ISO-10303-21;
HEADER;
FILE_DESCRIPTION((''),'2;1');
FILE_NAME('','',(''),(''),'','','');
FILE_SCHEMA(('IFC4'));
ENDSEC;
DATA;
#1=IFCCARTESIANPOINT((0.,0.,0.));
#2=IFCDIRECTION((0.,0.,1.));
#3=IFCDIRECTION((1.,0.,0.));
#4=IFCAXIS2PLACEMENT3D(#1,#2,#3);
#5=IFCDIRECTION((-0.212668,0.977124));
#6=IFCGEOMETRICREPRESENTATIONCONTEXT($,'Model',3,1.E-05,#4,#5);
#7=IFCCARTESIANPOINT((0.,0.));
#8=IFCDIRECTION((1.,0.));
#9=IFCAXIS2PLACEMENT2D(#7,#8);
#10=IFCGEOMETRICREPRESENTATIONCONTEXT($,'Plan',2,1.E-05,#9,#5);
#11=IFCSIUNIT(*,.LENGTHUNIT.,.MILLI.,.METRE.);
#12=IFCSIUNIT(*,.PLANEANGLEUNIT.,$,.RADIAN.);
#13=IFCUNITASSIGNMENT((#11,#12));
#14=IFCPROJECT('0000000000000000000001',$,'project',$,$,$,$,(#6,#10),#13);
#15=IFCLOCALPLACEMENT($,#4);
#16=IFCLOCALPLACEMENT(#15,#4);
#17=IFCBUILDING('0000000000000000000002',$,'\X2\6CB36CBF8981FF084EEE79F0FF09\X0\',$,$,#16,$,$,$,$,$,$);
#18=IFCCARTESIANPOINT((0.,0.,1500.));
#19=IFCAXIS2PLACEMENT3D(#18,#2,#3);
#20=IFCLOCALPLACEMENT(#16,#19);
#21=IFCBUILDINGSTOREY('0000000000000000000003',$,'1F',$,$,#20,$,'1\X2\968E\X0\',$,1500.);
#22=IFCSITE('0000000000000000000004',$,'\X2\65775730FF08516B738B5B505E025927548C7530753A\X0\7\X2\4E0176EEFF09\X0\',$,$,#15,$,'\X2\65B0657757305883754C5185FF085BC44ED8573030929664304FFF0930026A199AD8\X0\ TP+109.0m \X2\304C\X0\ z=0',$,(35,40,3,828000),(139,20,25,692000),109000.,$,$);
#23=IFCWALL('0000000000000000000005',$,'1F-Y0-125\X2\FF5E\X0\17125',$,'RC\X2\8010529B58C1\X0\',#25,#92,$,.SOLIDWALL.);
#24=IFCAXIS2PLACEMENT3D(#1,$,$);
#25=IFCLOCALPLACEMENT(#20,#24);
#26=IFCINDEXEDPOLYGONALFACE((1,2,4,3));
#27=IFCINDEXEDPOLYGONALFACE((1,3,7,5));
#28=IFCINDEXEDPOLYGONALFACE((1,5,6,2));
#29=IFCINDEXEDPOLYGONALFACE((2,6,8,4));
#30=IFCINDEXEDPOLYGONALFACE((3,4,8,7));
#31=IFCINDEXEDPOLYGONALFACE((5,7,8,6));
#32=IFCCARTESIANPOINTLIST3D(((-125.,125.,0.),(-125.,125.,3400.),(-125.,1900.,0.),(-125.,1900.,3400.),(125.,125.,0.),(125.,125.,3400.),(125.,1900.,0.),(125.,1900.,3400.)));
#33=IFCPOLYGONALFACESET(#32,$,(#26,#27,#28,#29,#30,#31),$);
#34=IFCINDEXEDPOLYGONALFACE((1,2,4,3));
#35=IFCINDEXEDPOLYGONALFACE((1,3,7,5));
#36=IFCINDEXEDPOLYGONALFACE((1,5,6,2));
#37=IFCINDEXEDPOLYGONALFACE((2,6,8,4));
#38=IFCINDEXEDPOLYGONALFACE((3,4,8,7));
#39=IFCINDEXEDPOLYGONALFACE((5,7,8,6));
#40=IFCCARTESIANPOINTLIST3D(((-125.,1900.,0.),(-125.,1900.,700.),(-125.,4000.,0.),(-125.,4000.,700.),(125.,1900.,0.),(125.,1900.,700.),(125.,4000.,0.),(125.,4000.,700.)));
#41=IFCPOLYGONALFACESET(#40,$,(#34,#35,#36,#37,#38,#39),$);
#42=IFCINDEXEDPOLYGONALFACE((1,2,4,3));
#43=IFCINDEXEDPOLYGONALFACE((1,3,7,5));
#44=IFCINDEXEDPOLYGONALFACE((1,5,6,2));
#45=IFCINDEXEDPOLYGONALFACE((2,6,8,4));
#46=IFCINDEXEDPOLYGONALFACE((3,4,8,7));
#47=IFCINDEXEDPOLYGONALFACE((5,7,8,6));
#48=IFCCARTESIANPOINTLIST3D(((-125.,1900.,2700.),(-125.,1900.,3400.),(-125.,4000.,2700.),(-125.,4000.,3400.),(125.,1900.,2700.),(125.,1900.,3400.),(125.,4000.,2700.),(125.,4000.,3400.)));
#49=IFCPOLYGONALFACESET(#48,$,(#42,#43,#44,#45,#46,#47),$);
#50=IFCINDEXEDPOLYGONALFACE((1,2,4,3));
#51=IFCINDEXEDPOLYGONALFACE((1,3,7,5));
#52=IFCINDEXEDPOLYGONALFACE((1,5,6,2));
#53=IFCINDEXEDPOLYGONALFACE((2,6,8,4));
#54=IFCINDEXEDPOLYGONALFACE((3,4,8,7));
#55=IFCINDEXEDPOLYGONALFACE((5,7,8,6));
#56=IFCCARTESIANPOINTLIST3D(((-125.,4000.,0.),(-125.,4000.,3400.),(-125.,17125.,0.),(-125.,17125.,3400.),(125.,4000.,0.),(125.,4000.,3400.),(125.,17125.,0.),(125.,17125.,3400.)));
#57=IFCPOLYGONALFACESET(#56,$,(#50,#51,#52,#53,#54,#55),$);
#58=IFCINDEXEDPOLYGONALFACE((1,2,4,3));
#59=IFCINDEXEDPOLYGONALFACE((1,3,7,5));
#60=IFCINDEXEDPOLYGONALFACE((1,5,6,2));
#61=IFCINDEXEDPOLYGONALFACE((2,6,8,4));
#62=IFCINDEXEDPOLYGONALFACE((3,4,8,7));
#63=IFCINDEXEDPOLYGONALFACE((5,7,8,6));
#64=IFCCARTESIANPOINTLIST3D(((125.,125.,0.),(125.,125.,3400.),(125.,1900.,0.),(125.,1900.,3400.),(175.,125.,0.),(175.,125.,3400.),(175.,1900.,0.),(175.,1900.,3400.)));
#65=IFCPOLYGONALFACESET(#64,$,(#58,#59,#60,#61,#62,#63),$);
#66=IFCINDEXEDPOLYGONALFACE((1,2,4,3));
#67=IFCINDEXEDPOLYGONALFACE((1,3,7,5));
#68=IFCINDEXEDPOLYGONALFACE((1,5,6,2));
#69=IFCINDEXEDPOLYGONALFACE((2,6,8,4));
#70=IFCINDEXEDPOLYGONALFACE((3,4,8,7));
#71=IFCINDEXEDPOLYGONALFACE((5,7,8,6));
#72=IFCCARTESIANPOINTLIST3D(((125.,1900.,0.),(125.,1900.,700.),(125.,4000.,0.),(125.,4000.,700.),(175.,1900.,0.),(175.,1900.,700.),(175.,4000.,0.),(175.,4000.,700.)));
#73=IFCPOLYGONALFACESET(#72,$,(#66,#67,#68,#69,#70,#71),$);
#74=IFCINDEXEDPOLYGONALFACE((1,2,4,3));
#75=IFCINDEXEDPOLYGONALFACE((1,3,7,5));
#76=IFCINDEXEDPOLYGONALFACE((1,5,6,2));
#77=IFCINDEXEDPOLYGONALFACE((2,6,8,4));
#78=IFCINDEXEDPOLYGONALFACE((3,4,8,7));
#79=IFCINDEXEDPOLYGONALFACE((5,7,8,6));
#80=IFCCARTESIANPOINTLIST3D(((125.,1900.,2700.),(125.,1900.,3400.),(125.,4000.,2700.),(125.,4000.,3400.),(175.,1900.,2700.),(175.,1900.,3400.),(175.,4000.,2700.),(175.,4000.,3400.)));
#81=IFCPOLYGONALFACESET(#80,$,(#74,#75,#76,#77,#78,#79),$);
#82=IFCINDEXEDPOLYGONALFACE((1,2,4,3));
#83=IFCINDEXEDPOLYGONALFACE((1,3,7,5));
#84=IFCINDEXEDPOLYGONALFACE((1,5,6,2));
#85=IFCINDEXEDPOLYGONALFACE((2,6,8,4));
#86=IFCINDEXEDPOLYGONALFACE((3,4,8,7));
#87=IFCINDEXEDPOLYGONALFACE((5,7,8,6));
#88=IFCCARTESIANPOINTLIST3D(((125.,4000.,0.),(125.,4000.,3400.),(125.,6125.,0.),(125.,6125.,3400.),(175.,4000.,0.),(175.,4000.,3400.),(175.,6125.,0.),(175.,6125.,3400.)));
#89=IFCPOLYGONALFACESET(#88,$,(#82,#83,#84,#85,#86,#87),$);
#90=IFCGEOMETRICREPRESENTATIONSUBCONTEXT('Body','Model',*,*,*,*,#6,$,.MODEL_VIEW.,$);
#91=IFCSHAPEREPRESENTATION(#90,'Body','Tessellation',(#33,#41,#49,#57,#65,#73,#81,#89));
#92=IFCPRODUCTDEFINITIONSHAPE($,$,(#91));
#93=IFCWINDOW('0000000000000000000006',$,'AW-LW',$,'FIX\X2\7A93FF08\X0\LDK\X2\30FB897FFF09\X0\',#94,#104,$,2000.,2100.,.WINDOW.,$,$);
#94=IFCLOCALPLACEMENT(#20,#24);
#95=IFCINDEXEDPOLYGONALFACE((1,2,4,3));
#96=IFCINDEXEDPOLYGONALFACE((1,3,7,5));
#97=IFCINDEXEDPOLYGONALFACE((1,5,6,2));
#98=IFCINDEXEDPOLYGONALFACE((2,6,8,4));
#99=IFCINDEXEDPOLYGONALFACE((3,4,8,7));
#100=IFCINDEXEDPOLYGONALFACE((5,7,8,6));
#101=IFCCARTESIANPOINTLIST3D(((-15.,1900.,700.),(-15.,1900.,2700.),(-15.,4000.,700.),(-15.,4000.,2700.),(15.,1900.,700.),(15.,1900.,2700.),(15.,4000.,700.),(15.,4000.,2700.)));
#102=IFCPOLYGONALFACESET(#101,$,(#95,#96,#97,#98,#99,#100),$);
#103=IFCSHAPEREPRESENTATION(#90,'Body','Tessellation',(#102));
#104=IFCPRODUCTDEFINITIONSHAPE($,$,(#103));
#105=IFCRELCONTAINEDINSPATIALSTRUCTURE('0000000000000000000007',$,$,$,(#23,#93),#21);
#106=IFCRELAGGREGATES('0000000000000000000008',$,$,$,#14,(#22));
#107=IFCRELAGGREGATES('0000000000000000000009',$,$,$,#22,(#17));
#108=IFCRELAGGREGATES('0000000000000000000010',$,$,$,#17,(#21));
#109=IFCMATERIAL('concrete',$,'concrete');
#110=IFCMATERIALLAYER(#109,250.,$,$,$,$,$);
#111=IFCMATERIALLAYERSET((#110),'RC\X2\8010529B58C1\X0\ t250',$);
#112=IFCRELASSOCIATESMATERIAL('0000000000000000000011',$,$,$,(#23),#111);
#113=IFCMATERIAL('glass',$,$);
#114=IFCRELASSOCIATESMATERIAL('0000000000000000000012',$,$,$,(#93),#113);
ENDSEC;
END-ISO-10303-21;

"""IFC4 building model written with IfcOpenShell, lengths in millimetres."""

from ifc_helpers import new_model, si_unit, direction, frame, frame_2d, origin, origin_with_axes, origin_2d_with_axis, place, context, subcontext, project, spatial, rectangle, extrude, material, layer, layer_set, layer_usage, element, fill, save


model = new_model("IFC4")

# Units and contexts
model_context = context("Model", 3, precision=1e-05, world=origin_with_axes(), true_north=direction((-0.212668, 0.977124)))
plan_context = context("Plan", 2, precision=1e-05, world=origin_2d_with_axis(), true_north=direction((-0.212668, 0.977124)))
body_context = subcontext(model_context, "Body", "Model", "MODEL_VIEW")
ifc_project = project(units=[si_unit("LENGTHUNIT", "METRE", prefix="MILLI"), si_unit("PLANEANGLEUNIT", "RADIAN")], contexts=[model_context, plan_context])

# Site, building, storey
site_placement = place(None, origin_with_axes())
site = spatial("IfcSite", under=ifc_project, at=site_placement, Name="敷地（八王子市大和田町7丁目）", LongName="新敷地境界内（寄付地を除く）。標高 TP+109.0m が z=0", RefLatitude=(35, 40, 3, 828000), RefLongitude=(139, 20, 25, 692000), RefElevation=109000.0)
building_placement = place(site_placement, origin_with_axes())
building = spatial("IfcBuilding", under=site, at=building_placement, Name="河沿要（仮称）")
storey_placement = place(building_placement, frame((0.0, 0.0, 1500.0), z_axis=(0.0, 0.0, 1.0), x_axis=(1.0, 0.0, 0.0)))
storey = spatial("IfcBuildingStorey", under=building, at=storey_placement, Name="1F", LongName="1階", Elevation=1500.0)

# Shared definitions
ifc_material_1 = material(Name="concrete", Category="concrete")
ifc_material_2 = material(Name="glass")

# Wall, opening, window
ifc_layer_1 = layer(ifc_material_1, 250.0)
ifc_layer_set_1 = layer_set([ifc_layer_1], Name="RC耐力壁 t250")
ifc_layer_usage_1 = layer_usage(ifc_layer_set_1, "AXIS2", "POSITIVE", 0.0)
wall_1_placement = place(storey_placement, origin_with_axes())
wall_1 = element("IfcWall", 1, at=wall_1_placement, inside=storey, material=ifc_layer_usage_1, Name="1F-Y0-125～17125", ObjectType="RC耐力壁", PredefinedType="SOLIDWALL", context=body_context, shape_type="SweptSolid", body=[
    extrude(rectangle(XDim=250.0, YDim=1775.0, at=frame_2d((0.0, 1012.5))), origin(), (0.0, 0.0, 1.0), 3400.0),
    extrude(rectangle(XDim=250.0, YDim=2100.0, at=frame_2d((0.0, 2950.0))), origin(), (0.0, 0.0, 1.0), 700.0),
    extrude(rectangle(XDim=250.0, YDim=2100.0, at=frame_2d((0.0, 2950.0))), frame((0.0, 0.0, 2700.0)), (0.0, 0.0, 1.0), 700.0),
    extrude(rectangle(XDim=250.0, YDim=13125.0, at=frame_2d((0.0, 10562.5))), origin(), (0.0, 0.0, 1.0), 3400.0),
    extrude(rectangle(XDim=50.0, YDim=1775.0, at=frame_2d((150.0, 1012.5))), origin(), (0.0, 0.0, 1.0), 3400.0),
    extrude(rectangle(XDim=50.0, YDim=2100.0, at=frame_2d((150.0, 2950.0))), origin(), (0.0, 0.0, 1.0), 700.0),
    extrude(rectangle(XDim=50.0, YDim=2100.0, at=frame_2d((150.0, 2950.0))), frame((0.0, 0.0, 2700.0)), (0.0, 0.0, 1.0), 700.0),
    extrude(rectangle(XDim=50.0, YDim=2125.0, at=frame_2d((150.0, 5062.5))), origin(), (0.0, 0.0, 1.0), 3400.0),
])
opening_1_placement = place(storey_placement, origin_with_axes())
opening_1 = element("IfcOpeningElement", 2, at=opening_1_placement, inside=storey, cuts=wall_1, PredefinedType="OPENING", context=body_context, shape_type="SweptSolid", body=[
    extrude(rectangle(XDim=300.0, YDim=2100.0, at=frame_2d((0.0, 2950.0))), frame((0.0, 0.0, 700.0)), (0.0, 0.0, 1.0), 2000.0),
])
window_1_placement = place(storey_placement, origin_with_axes())
window_1 = element("IfcWindow", 3, at=window_1_placement, inside=storey, material=ifc_material_2, Name="AW-LW", ObjectType="FIX窓（LDK・西）", OverallHeight=2000.0, OverallWidth=2100.0, PredefinedType="WINDOW", context=body_context, shape_type="SweptSolid", body=[
    extrude(rectangle(XDim=30.0, YDim=2100.0, at=frame_2d((0.0, 2950.0))), frame((0.0, 0.0, 700.0)), (0.0, 0.0, 1.0), 2000.0),
])
fill(opening_1, window_1)

save(model, "model.ifc")
